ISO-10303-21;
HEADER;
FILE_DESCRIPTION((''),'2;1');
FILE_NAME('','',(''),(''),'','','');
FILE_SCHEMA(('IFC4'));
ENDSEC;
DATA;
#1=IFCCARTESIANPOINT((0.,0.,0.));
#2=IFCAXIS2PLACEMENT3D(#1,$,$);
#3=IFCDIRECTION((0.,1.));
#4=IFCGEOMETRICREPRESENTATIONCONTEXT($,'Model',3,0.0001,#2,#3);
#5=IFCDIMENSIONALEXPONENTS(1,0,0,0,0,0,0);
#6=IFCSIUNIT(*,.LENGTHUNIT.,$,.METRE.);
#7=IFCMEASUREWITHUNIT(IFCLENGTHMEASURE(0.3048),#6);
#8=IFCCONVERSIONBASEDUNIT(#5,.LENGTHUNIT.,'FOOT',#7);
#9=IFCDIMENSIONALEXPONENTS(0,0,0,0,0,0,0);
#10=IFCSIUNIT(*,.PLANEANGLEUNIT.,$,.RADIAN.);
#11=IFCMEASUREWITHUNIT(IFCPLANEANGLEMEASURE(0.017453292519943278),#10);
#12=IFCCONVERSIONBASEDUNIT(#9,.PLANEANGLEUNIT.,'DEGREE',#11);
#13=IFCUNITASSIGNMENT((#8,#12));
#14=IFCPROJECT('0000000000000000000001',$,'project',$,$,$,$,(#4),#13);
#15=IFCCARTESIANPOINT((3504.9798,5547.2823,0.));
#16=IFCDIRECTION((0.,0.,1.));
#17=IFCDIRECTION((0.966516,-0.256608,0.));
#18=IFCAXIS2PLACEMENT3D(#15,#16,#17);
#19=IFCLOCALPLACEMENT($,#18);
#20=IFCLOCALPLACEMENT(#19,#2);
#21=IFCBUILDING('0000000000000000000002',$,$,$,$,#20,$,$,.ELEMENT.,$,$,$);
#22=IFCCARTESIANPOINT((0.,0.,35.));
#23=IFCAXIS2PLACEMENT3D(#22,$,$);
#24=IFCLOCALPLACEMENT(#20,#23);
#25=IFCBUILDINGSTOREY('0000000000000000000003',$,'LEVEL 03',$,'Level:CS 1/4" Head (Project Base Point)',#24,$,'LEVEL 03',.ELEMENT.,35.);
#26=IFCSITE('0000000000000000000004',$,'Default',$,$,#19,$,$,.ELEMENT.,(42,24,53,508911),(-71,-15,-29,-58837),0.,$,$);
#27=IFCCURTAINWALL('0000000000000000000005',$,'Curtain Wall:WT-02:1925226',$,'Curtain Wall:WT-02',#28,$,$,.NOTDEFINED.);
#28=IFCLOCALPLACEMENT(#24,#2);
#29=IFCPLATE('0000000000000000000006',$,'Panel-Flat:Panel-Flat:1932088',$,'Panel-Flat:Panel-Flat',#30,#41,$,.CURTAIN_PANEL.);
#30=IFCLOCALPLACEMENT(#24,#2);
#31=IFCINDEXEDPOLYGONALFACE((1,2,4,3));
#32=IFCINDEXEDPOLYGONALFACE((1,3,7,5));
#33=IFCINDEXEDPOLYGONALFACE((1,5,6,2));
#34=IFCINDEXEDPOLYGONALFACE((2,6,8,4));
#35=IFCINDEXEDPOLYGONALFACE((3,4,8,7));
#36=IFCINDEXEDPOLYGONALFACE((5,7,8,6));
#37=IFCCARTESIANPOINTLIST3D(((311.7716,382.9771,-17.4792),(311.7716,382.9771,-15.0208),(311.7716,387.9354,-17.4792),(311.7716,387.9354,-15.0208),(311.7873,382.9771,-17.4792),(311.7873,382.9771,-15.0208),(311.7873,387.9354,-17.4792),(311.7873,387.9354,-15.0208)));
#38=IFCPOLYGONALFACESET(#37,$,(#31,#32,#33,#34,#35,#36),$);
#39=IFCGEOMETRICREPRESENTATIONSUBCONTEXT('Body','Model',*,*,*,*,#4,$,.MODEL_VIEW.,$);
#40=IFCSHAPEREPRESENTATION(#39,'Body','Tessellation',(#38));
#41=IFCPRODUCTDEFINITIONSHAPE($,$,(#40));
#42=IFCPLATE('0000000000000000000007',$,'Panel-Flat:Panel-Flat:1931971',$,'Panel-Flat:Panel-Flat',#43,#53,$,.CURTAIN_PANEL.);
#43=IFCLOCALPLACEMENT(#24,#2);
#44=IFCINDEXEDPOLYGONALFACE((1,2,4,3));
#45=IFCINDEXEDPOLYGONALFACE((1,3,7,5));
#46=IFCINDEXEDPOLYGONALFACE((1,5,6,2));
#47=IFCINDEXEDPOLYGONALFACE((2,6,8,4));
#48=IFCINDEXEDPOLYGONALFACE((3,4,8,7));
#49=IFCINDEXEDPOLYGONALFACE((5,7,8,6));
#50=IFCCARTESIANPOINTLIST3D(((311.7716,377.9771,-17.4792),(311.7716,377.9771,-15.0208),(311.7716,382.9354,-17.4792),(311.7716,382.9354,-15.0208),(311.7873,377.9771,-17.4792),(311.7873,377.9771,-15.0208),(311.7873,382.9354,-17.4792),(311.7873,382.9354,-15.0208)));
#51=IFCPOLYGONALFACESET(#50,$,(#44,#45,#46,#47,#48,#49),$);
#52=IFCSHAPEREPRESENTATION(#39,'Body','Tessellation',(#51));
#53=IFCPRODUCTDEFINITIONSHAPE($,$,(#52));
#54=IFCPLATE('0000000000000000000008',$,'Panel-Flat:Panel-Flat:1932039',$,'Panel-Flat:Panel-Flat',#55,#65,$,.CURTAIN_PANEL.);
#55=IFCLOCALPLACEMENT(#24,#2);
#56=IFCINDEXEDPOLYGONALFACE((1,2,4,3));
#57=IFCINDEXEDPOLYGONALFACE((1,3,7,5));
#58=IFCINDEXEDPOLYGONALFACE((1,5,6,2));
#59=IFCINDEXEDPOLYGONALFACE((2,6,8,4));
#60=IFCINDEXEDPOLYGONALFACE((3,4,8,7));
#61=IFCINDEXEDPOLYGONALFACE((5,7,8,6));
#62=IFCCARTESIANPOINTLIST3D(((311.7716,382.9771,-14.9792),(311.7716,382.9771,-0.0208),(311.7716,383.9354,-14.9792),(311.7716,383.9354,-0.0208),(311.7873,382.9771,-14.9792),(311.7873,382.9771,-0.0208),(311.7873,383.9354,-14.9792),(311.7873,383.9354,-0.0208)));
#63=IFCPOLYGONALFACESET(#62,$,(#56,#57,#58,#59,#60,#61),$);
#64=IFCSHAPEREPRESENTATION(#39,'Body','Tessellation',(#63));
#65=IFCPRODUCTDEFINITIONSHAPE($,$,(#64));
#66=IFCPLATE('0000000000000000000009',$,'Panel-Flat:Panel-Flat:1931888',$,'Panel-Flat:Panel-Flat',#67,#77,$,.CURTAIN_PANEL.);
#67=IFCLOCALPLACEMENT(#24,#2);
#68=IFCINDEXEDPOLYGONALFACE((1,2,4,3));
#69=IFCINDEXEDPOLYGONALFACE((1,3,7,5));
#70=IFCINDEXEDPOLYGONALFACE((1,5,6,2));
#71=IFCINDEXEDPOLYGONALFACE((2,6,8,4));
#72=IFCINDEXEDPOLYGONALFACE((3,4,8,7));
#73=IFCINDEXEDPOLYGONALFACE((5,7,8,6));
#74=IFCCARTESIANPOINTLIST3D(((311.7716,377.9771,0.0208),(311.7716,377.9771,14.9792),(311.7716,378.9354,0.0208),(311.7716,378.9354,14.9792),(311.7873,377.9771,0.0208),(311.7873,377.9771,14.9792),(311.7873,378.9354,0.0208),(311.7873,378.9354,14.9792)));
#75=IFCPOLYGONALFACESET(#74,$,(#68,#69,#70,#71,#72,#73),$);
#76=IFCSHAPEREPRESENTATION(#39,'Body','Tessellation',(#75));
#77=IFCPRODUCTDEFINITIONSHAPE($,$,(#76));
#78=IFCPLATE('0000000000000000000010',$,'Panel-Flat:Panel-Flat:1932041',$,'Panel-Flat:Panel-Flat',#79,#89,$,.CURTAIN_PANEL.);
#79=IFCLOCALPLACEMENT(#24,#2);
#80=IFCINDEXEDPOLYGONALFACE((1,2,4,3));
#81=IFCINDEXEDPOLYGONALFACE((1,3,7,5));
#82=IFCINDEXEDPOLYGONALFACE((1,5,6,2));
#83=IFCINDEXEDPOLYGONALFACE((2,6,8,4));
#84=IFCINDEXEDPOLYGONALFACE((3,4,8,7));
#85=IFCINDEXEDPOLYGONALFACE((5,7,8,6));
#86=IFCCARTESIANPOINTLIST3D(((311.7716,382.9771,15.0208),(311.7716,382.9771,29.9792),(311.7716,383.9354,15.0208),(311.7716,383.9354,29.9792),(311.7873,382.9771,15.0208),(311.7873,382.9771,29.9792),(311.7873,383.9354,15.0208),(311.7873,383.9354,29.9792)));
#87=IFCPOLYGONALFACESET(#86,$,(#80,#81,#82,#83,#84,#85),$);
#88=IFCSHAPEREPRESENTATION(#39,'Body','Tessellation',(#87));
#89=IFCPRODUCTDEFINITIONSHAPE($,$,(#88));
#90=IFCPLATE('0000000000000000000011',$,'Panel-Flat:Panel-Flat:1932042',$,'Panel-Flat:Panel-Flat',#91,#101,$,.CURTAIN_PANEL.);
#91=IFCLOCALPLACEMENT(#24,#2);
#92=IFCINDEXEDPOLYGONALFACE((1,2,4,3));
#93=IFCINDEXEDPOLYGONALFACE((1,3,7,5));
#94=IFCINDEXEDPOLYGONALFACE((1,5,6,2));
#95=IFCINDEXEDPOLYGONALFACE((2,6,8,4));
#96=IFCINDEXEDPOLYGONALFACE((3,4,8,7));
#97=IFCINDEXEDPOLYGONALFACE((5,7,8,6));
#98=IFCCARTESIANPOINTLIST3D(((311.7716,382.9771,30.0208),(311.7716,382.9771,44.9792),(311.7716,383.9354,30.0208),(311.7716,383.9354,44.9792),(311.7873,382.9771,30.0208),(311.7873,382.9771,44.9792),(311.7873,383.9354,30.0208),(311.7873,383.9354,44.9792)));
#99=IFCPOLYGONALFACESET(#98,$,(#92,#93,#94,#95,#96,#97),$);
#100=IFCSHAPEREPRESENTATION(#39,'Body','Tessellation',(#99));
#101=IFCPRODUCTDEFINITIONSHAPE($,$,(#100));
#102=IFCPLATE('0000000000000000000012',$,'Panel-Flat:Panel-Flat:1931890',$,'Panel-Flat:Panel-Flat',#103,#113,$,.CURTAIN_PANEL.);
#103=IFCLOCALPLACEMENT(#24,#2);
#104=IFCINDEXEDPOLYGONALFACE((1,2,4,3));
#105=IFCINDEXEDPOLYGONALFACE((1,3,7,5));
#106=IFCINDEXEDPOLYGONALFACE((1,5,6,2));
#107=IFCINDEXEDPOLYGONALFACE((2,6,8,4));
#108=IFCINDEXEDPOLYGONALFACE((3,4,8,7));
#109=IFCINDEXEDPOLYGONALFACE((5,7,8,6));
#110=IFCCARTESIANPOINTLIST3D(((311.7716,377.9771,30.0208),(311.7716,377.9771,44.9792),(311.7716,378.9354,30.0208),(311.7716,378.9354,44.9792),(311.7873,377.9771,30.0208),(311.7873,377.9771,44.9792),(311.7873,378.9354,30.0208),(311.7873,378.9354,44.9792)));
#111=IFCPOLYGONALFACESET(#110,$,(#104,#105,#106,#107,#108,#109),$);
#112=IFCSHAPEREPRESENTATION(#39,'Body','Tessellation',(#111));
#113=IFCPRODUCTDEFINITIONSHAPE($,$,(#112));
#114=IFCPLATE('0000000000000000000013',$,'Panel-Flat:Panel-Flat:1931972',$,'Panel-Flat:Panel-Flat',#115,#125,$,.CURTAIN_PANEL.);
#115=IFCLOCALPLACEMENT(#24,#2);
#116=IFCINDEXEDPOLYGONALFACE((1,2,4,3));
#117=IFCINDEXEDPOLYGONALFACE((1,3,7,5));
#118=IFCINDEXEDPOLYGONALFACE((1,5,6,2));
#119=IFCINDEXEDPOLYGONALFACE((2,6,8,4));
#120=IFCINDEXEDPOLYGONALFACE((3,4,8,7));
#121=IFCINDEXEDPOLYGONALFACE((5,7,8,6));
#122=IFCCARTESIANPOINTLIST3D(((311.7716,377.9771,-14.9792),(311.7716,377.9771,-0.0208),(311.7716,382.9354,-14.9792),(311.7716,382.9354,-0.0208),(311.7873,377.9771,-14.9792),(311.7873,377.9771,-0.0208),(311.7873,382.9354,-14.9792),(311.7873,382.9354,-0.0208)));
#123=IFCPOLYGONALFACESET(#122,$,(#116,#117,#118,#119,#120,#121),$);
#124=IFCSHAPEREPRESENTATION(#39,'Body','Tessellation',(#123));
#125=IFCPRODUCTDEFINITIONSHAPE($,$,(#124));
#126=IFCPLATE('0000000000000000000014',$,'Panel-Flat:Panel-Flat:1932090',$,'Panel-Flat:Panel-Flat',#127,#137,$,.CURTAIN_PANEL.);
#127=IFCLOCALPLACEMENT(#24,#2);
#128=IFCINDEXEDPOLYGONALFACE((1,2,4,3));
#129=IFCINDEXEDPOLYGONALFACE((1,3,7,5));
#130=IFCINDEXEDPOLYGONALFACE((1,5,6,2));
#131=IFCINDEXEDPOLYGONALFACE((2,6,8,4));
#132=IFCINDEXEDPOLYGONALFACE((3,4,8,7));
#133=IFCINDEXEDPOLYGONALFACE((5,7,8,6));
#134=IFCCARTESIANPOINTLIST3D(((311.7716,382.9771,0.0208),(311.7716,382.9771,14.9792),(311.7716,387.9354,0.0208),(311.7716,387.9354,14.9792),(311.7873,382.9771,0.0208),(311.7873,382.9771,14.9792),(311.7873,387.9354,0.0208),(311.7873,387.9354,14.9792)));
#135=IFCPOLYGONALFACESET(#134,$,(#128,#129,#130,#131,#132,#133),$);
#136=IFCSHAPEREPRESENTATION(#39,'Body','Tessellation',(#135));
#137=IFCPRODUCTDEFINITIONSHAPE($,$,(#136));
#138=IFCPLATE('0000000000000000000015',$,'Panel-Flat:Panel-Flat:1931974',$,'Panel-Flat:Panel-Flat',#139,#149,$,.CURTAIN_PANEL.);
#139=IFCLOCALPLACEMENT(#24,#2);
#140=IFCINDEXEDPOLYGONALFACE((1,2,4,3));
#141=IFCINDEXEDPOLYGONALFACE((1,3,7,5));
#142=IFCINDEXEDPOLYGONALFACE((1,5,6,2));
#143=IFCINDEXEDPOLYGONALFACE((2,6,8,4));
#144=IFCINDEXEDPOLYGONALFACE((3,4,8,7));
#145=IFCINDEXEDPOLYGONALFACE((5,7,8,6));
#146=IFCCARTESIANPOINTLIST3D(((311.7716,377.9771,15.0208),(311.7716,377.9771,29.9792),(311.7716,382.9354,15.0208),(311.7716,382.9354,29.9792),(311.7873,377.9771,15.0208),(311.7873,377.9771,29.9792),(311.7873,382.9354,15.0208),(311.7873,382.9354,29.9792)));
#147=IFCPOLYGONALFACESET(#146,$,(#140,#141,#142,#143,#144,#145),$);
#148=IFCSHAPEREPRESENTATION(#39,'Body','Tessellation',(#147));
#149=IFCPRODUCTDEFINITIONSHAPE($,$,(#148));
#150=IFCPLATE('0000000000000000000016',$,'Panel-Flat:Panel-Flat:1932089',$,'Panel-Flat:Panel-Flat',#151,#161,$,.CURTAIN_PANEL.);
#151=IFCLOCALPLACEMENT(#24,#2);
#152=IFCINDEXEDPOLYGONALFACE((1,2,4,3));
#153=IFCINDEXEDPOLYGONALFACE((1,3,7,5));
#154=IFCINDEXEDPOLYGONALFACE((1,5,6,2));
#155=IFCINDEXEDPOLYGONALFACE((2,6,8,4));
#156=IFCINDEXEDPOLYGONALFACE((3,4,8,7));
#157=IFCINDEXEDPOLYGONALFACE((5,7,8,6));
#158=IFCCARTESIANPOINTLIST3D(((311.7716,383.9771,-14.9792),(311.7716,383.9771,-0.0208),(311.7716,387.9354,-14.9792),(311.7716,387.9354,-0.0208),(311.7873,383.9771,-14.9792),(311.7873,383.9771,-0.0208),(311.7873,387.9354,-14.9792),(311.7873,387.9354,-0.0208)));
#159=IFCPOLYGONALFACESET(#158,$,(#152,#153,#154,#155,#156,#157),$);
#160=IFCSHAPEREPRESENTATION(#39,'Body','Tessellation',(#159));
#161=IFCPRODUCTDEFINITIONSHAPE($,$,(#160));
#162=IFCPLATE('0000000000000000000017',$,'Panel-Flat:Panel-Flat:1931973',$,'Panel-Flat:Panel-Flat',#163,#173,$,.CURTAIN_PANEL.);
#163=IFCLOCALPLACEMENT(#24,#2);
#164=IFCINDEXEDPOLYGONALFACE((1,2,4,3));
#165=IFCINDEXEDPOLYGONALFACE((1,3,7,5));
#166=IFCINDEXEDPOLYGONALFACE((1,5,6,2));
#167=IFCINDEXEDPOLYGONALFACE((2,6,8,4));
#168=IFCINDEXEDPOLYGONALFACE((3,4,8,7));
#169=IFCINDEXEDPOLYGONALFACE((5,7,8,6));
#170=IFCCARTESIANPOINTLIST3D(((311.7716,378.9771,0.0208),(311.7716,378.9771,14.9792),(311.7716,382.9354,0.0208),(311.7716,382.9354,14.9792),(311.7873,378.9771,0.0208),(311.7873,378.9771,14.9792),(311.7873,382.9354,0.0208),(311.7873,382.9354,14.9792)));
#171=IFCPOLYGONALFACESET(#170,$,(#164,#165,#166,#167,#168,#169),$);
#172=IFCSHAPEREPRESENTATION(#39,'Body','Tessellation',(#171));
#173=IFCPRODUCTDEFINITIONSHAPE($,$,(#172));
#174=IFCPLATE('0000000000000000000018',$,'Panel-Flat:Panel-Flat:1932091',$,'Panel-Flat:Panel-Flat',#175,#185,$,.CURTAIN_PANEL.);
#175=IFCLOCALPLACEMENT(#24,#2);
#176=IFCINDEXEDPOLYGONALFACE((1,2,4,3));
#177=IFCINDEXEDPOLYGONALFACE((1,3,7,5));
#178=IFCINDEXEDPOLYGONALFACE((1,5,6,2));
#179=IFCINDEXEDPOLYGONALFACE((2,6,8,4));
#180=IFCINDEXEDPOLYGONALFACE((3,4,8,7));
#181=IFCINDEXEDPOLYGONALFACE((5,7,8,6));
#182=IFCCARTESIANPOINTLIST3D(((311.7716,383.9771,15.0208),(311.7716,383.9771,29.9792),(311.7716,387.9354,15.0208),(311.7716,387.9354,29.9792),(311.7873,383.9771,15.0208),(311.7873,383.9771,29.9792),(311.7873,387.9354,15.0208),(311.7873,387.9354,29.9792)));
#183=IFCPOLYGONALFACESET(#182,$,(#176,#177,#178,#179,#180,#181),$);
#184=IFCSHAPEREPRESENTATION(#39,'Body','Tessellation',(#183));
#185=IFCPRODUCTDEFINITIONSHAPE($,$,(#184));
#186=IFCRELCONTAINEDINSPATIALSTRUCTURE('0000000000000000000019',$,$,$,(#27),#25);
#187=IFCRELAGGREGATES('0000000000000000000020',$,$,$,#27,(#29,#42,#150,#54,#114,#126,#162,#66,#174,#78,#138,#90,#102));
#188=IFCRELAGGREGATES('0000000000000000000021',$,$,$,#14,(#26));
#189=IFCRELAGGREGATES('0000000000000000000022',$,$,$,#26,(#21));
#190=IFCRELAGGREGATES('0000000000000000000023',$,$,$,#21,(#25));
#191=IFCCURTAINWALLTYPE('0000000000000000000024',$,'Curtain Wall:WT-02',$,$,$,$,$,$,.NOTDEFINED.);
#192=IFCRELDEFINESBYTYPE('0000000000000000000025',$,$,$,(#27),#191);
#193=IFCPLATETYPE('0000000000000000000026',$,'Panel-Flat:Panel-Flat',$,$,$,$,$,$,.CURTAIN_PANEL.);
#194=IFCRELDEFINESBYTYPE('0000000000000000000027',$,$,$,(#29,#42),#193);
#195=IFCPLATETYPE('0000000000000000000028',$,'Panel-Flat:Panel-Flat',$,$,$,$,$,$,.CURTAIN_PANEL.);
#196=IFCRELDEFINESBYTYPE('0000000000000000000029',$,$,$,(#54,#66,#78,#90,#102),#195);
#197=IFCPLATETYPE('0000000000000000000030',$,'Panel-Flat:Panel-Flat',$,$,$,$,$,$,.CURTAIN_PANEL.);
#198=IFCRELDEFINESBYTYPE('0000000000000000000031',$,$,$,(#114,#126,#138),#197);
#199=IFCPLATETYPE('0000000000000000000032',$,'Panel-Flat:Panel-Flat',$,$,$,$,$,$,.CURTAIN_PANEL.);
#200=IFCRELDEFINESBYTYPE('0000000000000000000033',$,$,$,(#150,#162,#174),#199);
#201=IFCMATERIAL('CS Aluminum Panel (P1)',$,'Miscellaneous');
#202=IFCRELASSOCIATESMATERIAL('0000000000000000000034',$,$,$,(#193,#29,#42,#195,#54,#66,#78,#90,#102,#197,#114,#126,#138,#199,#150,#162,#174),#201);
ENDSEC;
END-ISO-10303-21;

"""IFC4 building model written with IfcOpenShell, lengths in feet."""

from ifc_helpers import new_model, entity, si_unit, converted_unit, direction, frame, origin, place, context, subcontext, project, spatial, indexed_curve, outline, extrude, source, transform, mapped, material, type_object, type_shapes, element, aggregate, save


model = new_model("IFC4")

# Units and contexts
model_context = context("Model", 3, precision=0.0001, world=origin(), true_north=direction((0.0, 1.0)))
body_context = subcontext(model_context, "Body", "Model", "MODEL_VIEW")
ifc_project = project(units=[converted_unit("LENGTHUNIT", "FOOT", entity("IfcLengthMeasure", 0.3048), si_unit("LENGTHUNIT", "METRE"), dimensions=[1, 0, 0, 0, 0, 0, 0]), converted_unit("PLANEANGLEUNIT", "DEGREE", entity("IfcPlaneAngleMeasure", 0.017453292519943278), si_unit("PLANEANGLEUNIT", "RADIAN"), dimensions=[0, 0, 0, 0, 0, 0, 0])], contexts=[model_context])

# Site, building, storey
site_placement = place(None, frame((3504.9798, 5547.2823, 0.0), z_axis=(0.0, 0.0, 1.0), x_axis=(0.966516, -0.256608, 0.0)))
site = spatial("IfcSite", under=ifc_project, at=site_placement, Name="Default", CompositionType="ELEMENT", RefLatitude=(42, 24, 53, 508911), RefLongitude=(-71, -15, -29, -58837), RefElevation=0.0)
building_placement = place(site_placement, origin())
building = spatial("IfcBuilding", under=site, at=building_placement, CompositionType="ELEMENT")
storey_placement = place(building_placement, frame((0.0, 0.0, 35.0)))
storey = spatial("IfcBuildingStorey", under=building, at=storey_placement, Name="LEVEL 03", ObjectType="Level:CS 1/4\" Head (Project Base Point)", LongName="LEVEL 03", CompositionType="ELEMENT", Elevation=35.0)

# Curtain wall, plates
curtain_wall_type = type_object("IfcCurtainWallType", Name="Curtain Wall:WT-02", PredefinedType="NOTDEFINED")
curtain_wall_1_placement = place(storey_placement, frame((0.0, 0.0, -35.0)))
curtain_wall_1 = element("IfcCurtainWall", 1, at=curtain_wall_1_placement, inside=storey, type_object=curtain_wall_type, Name="Curtain Wall:WT-02:1925226", ObjectType="Curtain Wall:WT-02", PredefinedType="NOTDEFINED")
ifc_material_1 = material(Name="CS Aluminum Panel (P1)", Category="Miscellaneous")
plate_type_1 = type_object("IfcPlateType", Name="Panel-Flat:Panel-Flat", PredefinedType="CURTAIN_PANEL", material=ifc_material_1)
shared_shape_1 = source(origin(), body_context, "Body", "SweptSolid", [
    extrude(outline(indexed_curve([(-0.0078, -2.4792), (0.0078, -2.4792), (0.0078, 2.4792), (-0.0078, 2.4792), (-0.0078, -2.4792)], self_intersect=False)), frame((0.0, -0.0078, 0.0208), z_axis=(0.0, 0.0, 1.0), x_axis=(0.0, -1.0, 0.0)), (0.0, 0.0, 1.0), 2.4583),
])
type_shapes(plate_type_1, [shared_shape_1])
plate_1_placement = place(curtain_wall_1_placement, frame((311.7873, 385.4563, 17.5), z_axis=(0.0, 0.0, 1.0), x_axis=(0.0, -1.0, 0.0)))
plate_1 = element("IfcPlate", 2, at=plate_1_placement, type_object=plate_type_1, material=ifc_material_1, Name="Panel-Flat:Panel-Flat:1932088", ObjectType="Panel-Flat:Panel-Flat", PredefinedType="CURTAIN_PANEL", context=body_context, shape_type="MappedRepresentation", body=[
    mapped(shared_shape_1, transform((0.0, 0.0, 0.0), scale=1.0)),
])
plate_2_placement = place(curtain_wall_1_placement, frame((311.7873, 380.4563, 17.5), z_axis=(0.0, 0.0, 1.0), x_axis=(0.0, -1.0, 0.0)))
plate_2 = element("IfcPlate", 3, at=plate_2_placement, type_object=plate_type_1, material=ifc_material_1, Name="Panel-Flat:Panel-Flat:1931971", ObjectType="Panel-Flat:Panel-Flat", PredefinedType="CURTAIN_PANEL", context=body_context, shape_type="MappedRepresentation", body=[
    mapped(shared_shape_1, transform((0.0, 0.0, 0.0), scale=1.0)),
])
plate_type_2 = type_object("IfcPlateType", Name="Panel-Flat:Panel-Flat", PredefinedType="CURTAIN_PANEL", material=ifc_material_1)
shared_shape_2 = source(origin(), body_context, "Body", "SweptSolid", [
    extrude(outline(indexed_curve([(-0.0078, -0.4792), (0.0078, -0.4792), (0.0078, 0.4792), (-0.0078, 0.4792), (-0.0078, -0.4792)], self_intersect=False)), frame((0.0, -0.0078, 0.0208), z_axis=(0.0, 0.0, 1.0), x_axis=(0.0, -1.0, 0.0)), (0.0, 0.0, 1.0), 14.9583),
])
type_shapes(plate_type_2, [shared_shape_2])
plate_3_placement = place(curtain_wall_1_placement, frame((311.7873, 383.4563, 20.0), z_axis=(0.0, 0.0, 1.0), x_axis=(0.0, -1.0, 0.0)))
plate_3 = element("IfcPlate", 4, at=plate_3_placement, type_object=plate_type_2, material=ifc_material_1, Name="Panel-Flat:Panel-Flat:1932039", ObjectType="Panel-Flat:Panel-Flat", PredefinedType="CURTAIN_PANEL", context=body_context, shape_type="MappedRepresentation", body=[
    mapped(shared_shape_2, transform((0.0, 0.0, 0.0), scale=1.0)),
])
plate_4_placement = place(curtain_wall_1_placement, frame((311.7873, 378.4563, 35.0), z_axis=(0.0, 0.0, 1.0), x_axis=(0.0, -1.0, 0.0)))
plate_4 = element("IfcPlate", 5, at=plate_4_placement, type_object=plate_type_2, material=ifc_material_1, Name="Panel-Flat:Panel-Flat:1931888", ObjectType="Panel-Flat:Panel-Flat", PredefinedType="CURTAIN_PANEL", context=body_context, shape_type="MappedRepresentation", body=[
    mapped(shared_shape_2, transform((0.0, 0.0, 0.0), scale=1.0)),
])
plate_5_placement = place(curtain_wall_1_placement, frame((311.7873, 383.4563, 50.0), z_axis=(0.0, 0.0, 1.0), x_axis=(0.0, -1.0, 0.0)))
plate_5 = element("IfcPlate", 6, at=plate_5_placement, type_object=plate_type_2, material=ifc_material_1, Name="Panel-Flat:Panel-Flat:1932041", ObjectType="Panel-Flat:Panel-Flat", PredefinedType="CURTAIN_PANEL", context=body_context, shape_type="MappedRepresentation", body=[
    mapped(shared_shape_2, transform((0.0, 0.0, 0.0), scale=1.0)),
])
plate_6_placement = place(curtain_wall_1_placement, frame((311.7873, 383.4563, 65.0), z_axis=(0.0, 0.0, 1.0), x_axis=(0.0, -1.0, 0.0)))
plate_6 = element("IfcPlate", 7, at=plate_6_placement, type_object=plate_type_2, material=ifc_material_1, Name="Panel-Flat:Panel-Flat:1932042", ObjectType="Panel-Flat:Panel-Flat", PredefinedType="CURTAIN_PANEL", context=body_context, shape_type="MappedRepresentation", body=[
    mapped(shared_shape_2, transform((0.0, 0.0, 0.0), scale=1.0)),
])
plate_7_placement = place(curtain_wall_1_placement, frame((311.7873, 378.4563, 65.0), z_axis=(0.0, 0.0, 1.0), x_axis=(0.0, -1.0, 0.0)))
plate_7 = element("IfcPlate", 8, at=plate_7_placement, type_object=plate_type_2, material=ifc_material_1, Name="Panel-Flat:Panel-Flat:1931890", ObjectType="Panel-Flat:Panel-Flat", PredefinedType="CURTAIN_PANEL", context=body_context, shape_type="MappedRepresentation", body=[
    mapped(shared_shape_2, transform((0.0, 0.0, 0.0), scale=1.0)),
])
plate_type_3 = type_object("IfcPlateType", Name="Panel-Flat:Panel-Flat", PredefinedType="CURTAIN_PANEL", material=ifc_material_1)
shared_shape_3 = source(origin(), body_context, "Body", "SweptSolid", [
    extrude(outline(indexed_curve([(-0.0078, -2.4792), (0.0078, -2.4792), (0.0078, 2.4792), (-0.0078, 2.4792), (-0.0078, -2.4792)], self_intersect=False)), frame((0.0, -0.0078, 0.0208), z_axis=(0.0, 0.0, 1.0), x_axis=(0.0, -1.0, 0.0)), (0.0, 0.0, 1.0), 14.9583),
])
type_shapes(plate_type_3, [shared_shape_3])
plate_8_placement = place(curtain_wall_1_placement, frame((311.7873, 380.4563, 20.0), z_axis=(0.0, 0.0, 1.0), x_axis=(0.0, -1.0, 0.0)))
plate_8 = element("IfcPlate", 9, at=plate_8_placement, type_object=plate_type_3, material=ifc_material_1, Name="Panel-Flat:Panel-Flat:1931972", ObjectType="Panel-Flat:Panel-Flat", PredefinedType="CURTAIN_PANEL", context=body_context, shape_type="MappedRepresentation", body=[
    mapped(shared_shape_3, transform((0.0, 0.0, 0.0), scale=1.0)),
])
plate_9_placement = place(curtain_wall_1_placement, frame((311.7873, 385.4563, 35.0), z_axis=(0.0, 0.0, 1.0), x_axis=(0.0, -1.0, 0.0)))
plate_9 = element("IfcPlate", 10, at=plate_9_placement, type_object=plate_type_3, material=ifc_material_1, Name="Panel-Flat:Panel-Flat:1932090", ObjectType="Panel-Flat:Panel-Flat", PredefinedType="CURTAIN_PANEL", context=body_context, shape_type="MappedRepresentation", body=[
    mapped(shared_shape_3, transform((0.0, 0.0, 0.0), scale=1.0)),
])
plate_10_placement = place(curtain_wall_1_placement, frame((311.7873, 380.4563, 50.0), z_axis=(0.0, 0.0, 1.0), x_axis=(0.0, -1.0, 0.0)))
plate_10 = element("IfcPlate", 11, at=plate_10_placement, type_object=plate_type_3, material=ifc_material_1, Name="Panel-Flat:Panel-Flat:1931974", ObjectType="Panel-Flat:Panel-Flat", PredefinedType="CURTAIN_PANEL", context=body_context, shape_type="MappedRepresentation", body=[
    mapped(shared_shape_3, transform((0.0, 0.0, 0.0), scale=1.0)),
])
plate_type_4 = type_object("IfcPlateType", Name="Panel-Flat:Panel-Flat", PredefinedType="CURTAIN_PANEL", material=ifc_material_1)
shared_shape_4 = source(origin(), body_context, "Body", "SweptSolid", [
    extrude(outline(indexed_curve([(-0.0078, -1.9792), (0.0078, -1.9792), (0.0078, 1.9792), (-0.0078, 1.9792), (-0.0078, -1.9792)], self_intersect=False)), frame((0.0, -0.0078, 0.0208), z_axis=(0.0, 0.0, 1.0), x_axis=(0.0, -1.0, 0.0)), (0.0, 0.0, 1.0), 14.9583),
])
type_shapes(plate_type_4, [shared_shape_4])
plate_11_placement = place(curtain_wall_1_placement, frame((311.7873, 385.9563, 20.0), z_axis=(0.0, 0.0, 1.0), x_axis=(0.0, -1.0, 0.0)))
plate_11 = element("IfcPlate", 12, at=plate_11_placement, type_object=plate_type_4, material=ifc_material_1, Name="Panel-Flat:Panel-Flat:1932089", ObjectType="Panel-Flat:Panel-Flat", PredefinedType="CURTAIN_PANEL", context=body_context, shape_type="MappedRepresentation", body=[
    mapped(shared_shape_4, transform((0.0, 0.0, 0.0), scale=1.0)),
])
plate_12_placement = place(curtain_wall_1_placement, frame((311.7873, 380.9563, 35.0), z_axis=(0.0, 0.0, 1.0), x_axis=(0.0, -1.0, 0.0)))
plate_12 = element("IfcPlate", 13, at=plate_12_placement, type_object=plate_type_4, material=ifc_material_1, Name="Panel-Flat:Panel-Flat:1931973", ObjectType="Panel-Flat:Panel-Flat", PredefinedType="CURTAIN_PANEL", context=body_context, shape_type="MappedRepresentation", body=[
    mapped(shared_shape_4, transform((0.0, 0.0, 0.0), scale=1.0)),
])
plate_13_placement = place(curtain_wall_1_placement, frame((311.7873, 385.9563, 50.0), z_axis=(0.0, 0.0, 1.0), x_axis=(0.0, -1.0, 0.0)))
plate_13 = element("IfcPlate", 14, at=plate_13_placement, type_object=plate_type_4, material=ifc_material_1, Name="Panel-Flat:Panel-Flat:1932091", ObjectType="Panel-Flat:Panel-Flat", PredefinedType="CURTAIN_PANEL", context=body_context, shape_type="MappedRepresentation", body=[
    mapped(shared_shape_4, transform((0.0, 0.0, 0.0), scale=1.0)),
])
aggregate(curtain_wall_1, [plate_1, plate_2, plate_11, plate_3, plate_8, plate_9, plate_12, plate_4, plate_13, plate_5, plate_10, plate_6, plate_7])

save(model, "model.ifc")
